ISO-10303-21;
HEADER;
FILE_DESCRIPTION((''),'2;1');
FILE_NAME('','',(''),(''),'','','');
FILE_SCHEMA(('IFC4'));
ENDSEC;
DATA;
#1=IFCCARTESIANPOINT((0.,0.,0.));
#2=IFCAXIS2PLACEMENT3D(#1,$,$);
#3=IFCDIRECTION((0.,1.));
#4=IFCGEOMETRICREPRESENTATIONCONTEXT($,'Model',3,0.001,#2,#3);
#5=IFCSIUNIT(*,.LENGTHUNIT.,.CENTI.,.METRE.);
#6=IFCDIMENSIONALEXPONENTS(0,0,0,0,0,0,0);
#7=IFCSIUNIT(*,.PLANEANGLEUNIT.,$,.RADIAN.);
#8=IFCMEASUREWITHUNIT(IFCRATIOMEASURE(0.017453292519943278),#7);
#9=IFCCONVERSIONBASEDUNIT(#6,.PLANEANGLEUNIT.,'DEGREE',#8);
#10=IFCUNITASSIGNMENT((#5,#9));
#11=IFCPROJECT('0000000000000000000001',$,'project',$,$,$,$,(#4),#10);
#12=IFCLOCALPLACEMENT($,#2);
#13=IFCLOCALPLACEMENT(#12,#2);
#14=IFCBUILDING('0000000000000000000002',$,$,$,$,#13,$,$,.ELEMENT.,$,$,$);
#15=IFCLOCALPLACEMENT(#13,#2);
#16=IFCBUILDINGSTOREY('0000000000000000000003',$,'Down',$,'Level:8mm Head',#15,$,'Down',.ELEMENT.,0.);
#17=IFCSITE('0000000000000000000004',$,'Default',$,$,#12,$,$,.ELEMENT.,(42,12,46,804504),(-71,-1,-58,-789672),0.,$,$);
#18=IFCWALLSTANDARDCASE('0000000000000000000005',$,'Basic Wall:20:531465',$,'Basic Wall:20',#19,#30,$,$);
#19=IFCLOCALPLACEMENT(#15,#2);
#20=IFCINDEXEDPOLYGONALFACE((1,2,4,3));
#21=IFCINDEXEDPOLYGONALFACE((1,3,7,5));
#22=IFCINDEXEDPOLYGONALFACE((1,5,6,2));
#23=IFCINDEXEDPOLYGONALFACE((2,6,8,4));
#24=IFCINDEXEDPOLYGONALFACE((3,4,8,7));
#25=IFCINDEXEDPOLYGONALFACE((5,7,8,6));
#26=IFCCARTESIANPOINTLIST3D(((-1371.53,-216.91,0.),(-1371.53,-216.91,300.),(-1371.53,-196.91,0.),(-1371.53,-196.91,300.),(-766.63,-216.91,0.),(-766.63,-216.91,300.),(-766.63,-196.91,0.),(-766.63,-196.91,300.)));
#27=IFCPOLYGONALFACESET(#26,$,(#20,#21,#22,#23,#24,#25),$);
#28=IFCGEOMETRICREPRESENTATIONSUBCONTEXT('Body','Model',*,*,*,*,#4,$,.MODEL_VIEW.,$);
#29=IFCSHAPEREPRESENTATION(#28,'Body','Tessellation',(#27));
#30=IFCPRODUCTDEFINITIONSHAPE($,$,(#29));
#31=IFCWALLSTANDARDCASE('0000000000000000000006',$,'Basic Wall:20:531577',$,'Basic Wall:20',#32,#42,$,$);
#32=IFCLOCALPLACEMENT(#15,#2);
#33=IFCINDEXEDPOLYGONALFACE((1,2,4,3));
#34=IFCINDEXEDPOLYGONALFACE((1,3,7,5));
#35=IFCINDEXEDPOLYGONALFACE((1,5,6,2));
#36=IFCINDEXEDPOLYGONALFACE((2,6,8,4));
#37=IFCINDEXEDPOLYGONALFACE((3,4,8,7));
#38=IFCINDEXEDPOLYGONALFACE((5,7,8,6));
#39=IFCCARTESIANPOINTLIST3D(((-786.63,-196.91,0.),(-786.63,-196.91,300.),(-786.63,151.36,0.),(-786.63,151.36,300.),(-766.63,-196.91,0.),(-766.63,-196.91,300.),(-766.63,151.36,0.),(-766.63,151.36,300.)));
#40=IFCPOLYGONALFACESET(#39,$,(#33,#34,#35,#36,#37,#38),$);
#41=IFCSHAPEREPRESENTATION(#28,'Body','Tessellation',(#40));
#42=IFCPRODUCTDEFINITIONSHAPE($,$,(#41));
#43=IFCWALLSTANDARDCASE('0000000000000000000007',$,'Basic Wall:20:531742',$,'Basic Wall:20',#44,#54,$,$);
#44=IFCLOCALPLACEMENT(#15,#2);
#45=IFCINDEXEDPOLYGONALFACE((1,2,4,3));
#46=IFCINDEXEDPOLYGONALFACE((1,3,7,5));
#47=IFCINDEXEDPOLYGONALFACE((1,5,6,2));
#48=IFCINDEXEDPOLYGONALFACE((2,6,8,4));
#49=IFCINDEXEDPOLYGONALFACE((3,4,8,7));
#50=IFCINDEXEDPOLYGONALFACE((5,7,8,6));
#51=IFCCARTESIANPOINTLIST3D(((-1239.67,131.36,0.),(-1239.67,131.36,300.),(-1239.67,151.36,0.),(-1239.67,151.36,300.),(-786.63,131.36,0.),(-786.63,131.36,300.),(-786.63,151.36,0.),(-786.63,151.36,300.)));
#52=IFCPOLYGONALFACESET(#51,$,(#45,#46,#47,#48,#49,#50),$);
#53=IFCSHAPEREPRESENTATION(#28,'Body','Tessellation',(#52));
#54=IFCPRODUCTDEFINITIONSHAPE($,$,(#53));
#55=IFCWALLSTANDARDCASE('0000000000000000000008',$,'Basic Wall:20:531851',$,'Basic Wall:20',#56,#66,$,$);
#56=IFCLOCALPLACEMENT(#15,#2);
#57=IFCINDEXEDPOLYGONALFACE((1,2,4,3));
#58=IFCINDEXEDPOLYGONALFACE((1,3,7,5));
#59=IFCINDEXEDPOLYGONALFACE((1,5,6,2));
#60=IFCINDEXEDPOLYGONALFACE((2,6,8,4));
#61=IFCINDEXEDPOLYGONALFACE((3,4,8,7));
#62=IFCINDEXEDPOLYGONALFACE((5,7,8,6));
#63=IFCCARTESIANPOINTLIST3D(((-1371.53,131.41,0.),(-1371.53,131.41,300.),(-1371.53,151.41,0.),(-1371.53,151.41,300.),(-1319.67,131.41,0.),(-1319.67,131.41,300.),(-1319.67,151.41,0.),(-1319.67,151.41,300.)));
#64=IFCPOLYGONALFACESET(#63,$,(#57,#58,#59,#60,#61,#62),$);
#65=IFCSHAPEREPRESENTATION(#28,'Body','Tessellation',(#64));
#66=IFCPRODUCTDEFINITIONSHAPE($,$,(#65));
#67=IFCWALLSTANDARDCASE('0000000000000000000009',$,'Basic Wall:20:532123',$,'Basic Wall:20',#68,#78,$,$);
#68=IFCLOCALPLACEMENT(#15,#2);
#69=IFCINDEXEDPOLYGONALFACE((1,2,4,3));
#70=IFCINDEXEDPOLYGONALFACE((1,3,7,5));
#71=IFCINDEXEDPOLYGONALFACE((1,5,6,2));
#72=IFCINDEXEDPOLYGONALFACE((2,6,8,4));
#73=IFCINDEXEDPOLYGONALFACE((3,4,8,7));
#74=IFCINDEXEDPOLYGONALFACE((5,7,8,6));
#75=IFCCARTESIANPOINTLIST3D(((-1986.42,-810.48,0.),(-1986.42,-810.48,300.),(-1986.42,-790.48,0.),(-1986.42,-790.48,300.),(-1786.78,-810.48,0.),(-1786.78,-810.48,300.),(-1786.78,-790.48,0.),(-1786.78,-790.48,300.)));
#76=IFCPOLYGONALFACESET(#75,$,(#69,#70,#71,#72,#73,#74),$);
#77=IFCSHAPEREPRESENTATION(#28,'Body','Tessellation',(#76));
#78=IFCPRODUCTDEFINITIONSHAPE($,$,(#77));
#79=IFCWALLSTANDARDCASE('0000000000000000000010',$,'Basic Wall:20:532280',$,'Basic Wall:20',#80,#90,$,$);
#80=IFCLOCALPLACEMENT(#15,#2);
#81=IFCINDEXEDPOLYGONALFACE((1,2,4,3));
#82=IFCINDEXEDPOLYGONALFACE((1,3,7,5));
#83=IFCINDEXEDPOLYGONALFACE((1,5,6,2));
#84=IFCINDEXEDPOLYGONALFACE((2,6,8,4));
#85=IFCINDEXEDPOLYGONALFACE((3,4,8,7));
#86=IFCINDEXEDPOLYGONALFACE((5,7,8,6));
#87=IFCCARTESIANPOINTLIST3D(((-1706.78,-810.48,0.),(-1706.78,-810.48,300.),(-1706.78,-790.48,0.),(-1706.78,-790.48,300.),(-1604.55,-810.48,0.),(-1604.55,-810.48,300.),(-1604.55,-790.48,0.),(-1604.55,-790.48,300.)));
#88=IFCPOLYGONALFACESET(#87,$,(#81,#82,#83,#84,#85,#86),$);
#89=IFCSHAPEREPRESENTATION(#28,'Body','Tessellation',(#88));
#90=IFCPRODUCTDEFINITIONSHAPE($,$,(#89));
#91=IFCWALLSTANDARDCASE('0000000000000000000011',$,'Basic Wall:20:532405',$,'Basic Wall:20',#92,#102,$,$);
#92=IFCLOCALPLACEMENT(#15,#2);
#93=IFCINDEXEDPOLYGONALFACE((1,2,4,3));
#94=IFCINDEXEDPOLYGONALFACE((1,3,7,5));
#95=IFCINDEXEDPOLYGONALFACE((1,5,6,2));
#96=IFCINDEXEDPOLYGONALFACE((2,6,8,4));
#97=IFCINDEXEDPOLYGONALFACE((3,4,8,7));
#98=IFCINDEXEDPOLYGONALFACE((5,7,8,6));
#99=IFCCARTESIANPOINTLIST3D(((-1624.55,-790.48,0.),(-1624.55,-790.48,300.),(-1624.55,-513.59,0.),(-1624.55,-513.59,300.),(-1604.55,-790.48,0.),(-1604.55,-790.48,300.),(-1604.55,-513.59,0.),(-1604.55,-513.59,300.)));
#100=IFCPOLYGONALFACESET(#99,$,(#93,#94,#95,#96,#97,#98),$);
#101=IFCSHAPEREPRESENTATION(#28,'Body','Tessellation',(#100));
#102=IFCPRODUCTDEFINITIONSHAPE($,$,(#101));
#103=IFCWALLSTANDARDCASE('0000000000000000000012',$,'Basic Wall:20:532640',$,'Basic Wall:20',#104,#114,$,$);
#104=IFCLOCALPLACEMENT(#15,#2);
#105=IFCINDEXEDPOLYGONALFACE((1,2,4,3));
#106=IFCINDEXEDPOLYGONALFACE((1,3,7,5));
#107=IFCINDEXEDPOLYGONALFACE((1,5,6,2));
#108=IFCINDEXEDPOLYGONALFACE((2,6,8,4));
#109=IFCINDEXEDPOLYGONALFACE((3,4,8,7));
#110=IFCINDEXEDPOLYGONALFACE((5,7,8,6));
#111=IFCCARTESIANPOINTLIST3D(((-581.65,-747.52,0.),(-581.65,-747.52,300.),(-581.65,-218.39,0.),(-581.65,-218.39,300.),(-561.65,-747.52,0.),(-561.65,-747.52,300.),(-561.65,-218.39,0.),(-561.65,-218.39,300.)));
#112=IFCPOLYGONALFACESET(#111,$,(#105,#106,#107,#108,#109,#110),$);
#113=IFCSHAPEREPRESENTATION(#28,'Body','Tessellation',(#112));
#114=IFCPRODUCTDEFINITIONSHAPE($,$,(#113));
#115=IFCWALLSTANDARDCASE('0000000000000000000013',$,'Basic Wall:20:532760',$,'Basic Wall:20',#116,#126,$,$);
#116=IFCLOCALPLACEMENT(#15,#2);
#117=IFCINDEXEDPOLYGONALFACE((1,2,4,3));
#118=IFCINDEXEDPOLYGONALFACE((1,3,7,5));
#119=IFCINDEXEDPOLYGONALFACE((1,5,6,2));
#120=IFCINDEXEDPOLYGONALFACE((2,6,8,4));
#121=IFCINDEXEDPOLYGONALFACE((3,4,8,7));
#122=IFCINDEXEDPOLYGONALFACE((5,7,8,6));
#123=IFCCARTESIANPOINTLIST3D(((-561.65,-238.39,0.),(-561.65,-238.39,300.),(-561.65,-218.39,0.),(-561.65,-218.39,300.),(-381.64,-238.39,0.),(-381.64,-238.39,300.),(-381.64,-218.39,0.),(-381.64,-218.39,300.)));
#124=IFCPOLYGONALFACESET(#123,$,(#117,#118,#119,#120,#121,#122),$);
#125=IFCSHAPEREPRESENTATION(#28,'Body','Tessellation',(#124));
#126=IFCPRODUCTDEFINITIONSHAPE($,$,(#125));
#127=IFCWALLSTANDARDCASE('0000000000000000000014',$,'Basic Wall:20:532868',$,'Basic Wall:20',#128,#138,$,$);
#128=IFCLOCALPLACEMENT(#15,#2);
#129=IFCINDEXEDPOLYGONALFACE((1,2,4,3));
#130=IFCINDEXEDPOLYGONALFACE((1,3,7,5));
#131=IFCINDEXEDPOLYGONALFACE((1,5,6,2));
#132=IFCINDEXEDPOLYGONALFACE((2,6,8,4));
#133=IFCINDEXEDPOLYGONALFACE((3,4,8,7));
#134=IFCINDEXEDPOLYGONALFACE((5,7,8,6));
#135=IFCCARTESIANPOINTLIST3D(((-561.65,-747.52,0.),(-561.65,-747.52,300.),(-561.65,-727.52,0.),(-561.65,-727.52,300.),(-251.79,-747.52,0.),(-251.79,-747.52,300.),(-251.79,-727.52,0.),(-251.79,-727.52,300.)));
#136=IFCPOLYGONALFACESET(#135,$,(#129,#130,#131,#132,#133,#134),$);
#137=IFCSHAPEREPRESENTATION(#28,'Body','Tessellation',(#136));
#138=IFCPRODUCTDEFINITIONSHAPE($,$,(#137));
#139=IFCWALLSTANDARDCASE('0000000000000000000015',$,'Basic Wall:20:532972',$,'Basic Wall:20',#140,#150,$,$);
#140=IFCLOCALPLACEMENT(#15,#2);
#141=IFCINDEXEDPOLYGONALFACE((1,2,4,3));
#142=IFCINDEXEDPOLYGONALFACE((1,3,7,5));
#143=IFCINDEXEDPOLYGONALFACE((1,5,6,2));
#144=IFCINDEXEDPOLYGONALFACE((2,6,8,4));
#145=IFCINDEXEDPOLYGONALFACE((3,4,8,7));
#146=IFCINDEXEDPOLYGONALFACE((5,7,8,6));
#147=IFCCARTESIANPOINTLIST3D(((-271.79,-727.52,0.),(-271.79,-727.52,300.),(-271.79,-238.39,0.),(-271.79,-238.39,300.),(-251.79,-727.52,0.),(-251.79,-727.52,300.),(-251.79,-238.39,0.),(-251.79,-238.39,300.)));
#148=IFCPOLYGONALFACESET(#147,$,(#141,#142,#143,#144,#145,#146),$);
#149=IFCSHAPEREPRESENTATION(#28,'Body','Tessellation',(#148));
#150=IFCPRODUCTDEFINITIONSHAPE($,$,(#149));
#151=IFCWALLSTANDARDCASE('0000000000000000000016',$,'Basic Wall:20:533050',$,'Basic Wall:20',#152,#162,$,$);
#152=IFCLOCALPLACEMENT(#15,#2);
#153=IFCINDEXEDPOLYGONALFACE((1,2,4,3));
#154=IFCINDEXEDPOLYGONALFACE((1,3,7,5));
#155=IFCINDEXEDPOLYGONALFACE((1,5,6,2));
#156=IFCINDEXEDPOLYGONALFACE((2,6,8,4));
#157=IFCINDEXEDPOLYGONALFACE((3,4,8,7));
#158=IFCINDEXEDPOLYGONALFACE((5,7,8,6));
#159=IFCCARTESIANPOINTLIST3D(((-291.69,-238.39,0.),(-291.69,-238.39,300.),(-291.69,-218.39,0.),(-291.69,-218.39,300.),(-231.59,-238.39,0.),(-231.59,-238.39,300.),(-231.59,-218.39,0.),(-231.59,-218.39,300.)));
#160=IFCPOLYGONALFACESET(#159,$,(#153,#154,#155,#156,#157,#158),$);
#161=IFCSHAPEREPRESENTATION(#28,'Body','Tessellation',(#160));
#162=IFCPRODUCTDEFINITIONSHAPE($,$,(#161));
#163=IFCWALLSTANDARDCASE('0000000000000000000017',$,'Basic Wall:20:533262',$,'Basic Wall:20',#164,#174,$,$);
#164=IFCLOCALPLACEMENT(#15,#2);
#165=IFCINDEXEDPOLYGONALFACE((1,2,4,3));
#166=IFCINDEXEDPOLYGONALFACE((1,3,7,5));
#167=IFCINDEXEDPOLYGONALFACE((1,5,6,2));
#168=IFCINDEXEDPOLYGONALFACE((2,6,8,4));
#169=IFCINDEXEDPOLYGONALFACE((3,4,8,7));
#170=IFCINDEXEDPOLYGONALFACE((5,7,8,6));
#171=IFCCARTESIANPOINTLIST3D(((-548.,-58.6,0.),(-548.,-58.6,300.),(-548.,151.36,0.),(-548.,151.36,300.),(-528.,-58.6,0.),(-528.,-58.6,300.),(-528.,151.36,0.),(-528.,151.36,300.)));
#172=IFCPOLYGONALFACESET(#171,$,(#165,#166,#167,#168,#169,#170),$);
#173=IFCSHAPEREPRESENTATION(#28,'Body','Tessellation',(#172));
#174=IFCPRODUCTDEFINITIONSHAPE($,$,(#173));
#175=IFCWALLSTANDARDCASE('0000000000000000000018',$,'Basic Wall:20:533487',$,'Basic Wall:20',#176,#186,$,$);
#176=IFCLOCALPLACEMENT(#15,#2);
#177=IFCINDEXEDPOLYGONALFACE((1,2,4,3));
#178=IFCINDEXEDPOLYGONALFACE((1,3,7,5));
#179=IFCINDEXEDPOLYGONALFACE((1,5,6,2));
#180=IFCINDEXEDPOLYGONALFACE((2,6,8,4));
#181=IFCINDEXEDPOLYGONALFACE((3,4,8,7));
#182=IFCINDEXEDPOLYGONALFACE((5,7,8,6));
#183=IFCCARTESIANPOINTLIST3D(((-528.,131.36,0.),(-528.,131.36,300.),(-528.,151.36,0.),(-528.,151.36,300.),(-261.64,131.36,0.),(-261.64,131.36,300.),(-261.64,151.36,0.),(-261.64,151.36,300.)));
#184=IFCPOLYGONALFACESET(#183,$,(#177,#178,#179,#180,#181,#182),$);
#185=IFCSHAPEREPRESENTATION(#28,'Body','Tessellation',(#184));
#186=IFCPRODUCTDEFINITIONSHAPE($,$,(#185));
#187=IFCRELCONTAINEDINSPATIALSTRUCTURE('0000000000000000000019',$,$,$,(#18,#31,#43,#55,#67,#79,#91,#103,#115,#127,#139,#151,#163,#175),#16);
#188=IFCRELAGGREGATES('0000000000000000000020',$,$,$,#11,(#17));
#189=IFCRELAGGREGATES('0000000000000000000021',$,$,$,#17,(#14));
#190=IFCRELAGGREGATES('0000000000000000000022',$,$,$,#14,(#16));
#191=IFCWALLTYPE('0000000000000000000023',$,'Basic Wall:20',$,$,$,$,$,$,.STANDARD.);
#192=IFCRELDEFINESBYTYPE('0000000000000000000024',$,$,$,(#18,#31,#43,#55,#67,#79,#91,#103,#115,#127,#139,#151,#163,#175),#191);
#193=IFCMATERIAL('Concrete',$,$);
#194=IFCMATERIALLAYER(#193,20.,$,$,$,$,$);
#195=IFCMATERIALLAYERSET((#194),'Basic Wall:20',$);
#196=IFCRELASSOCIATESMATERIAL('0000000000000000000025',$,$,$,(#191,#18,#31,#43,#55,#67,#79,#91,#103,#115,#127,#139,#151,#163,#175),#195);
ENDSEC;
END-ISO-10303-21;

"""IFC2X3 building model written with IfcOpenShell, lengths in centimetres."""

from ifc_helpers import new_model, entity, si_unit, converted_unit, direction, frame, frame_2d, origin, place, context, subcontext, project, spatial, rectangle, extrude, material, layer, layer_set, layer_usage, type_object, element, save


model = new_model("IFC2X3")

# Units and contexts
model_context = context("Model", 3, precision=0.001, world=origin(), true_north=direction((0.0, 1.0)))
body_context = subcontext(model_context, "Body", "Model", "MODEL_VIEW")
ifc_project = project(units=[si_unit("LENGTHUNIT", "METRE", prefix="CENTI"), converted_unit("PLANEANGLEUNIT", "DEGREE", entity("IfcRatioMeasure", 0.017453292519943278), si_unit("PLANEANGLEUNIT", "RADIAN"), dimensions=[0, 0, 0, 0, 0, 0, 0])], contexts=[model_context])

# Site, building, storey
site_placement = place(None, origin())
site = spatial("IfcSite", under=ifc_project, at=site_placement, Name="Default", CompositionType="ELEMENT", RefLatitude=(42, 12, 46, 804504), RefLongitude=(-71, -1, -58, -789672), RefElevation=0.0)
building_placement = place(site_placement, origin())
building = spatial("IfcBuilding", under=site, at=building_placement, CompositionType="ELEMENT")
storey_placement = place(building_placement, origin())
storey = spatial("IfcBuildingStorey", under=building, at=storey_placement, Name="Down", ObjectType="Level:8mm Head", LongName="Down", CompositionType="ELEMENT", Elevation=0.0)

# Shared definitions
ifc_material = material(Name="Concrete")

# Walls
ifc_layer_1 = layer(ifc_material, 20.0)
ifc_layer_set_1 = layer_set([ifc_layer_1], Name="Basic Wall:20")
ifc_layer_usage_1 = layer_usage(ifc_layer_set_1, "AXIS2", "POSITIVE", -10.0)
wall_type_1 = type_object("IfcWallType", Name="Basic Wall:20", PredefinedType="STANDARD", material=ifc_layer_set_1)
wall_1_placement = place(storey_placement, frame((-1371.53, -206.91, 0.0)))
element("IfcWallStandardCase", 1, at=wall_1_placement, inside=storey, type_object=wall_type_1, material=ifc_layer_usage_1, Name="Basic Wall:20:531465", ObjectType="Basic Wall:20", context=body_context, shape_type="SweptSolid", body=[
    extrude(rectangle(XDim=604.9, YDim=20.0, at=frame_2d((302.45, 0.0), x_axis=(-1.0, 0.0))), origin(), (0.0, 0.0, 1.0), 300.0),
])
ifc_layer_usage_2 = layer_usage(ifc_layer_set_1, "AXIS2", "POSITIVE", -10.0)
wall_2_placement = place(storey_placement, frame((-776.63, -196.91, 0.0), z_axis=(0.0, 0.0, 1.0), x_axis=(0.0, 1.0, 0.0)))
element("IfcWallStandardCase", 2, at=wall_2_placement, inside=storey, type_object=wall_type_1, material=ifc_layer_usage_2, Name="Basic Wall:20:531577", ObjectType="Basic Wall:20", context=body_context, shape_type="SweptSolid", body=[
    extrude(rectangle(XDim=348.27, YDim=20.0, at=frame_2d((174.14, 0.0), x_axis=(-1.0, 0.0))), origin(), (0.0, 0.0, 1.0), 300.0),
])
ifc_layer_usage_3 = layer_usage(ifc_layer_set_1, "AXIS2", "POSITIVE", -10.0)
wall_3_placement = place(storey_placement, frame((-786.63, 141.36, 0.0), z_axis=(0.0, 0.0, 1.0), x_axis=(-1.0, 0.0, 0.0)))
element("IfcWallStandardCase", 3, at=wall_3_placement, inside=storey, type_object=wall_type_1, material=ifc_layer_usage_3, Name="Basic Wall:20:531742", ObjectType="Basic Wall:20", context=body_context, shape_type="SweptSolid", body=[
    extrude(rectangle(XDim=453.04, YDim=20.0, at=frame_2d((226.52, 0.0), x_axis=(-1.0, 0.0))), origin(), (0.0, 0.0, 1.0), 300.0),
])
ifc_layer_usage_4 = layer_usage(ifc_layer_set_1, "AXIS2", "POSITIVE", -10.0)
wall_4_placement = place(storey_placement, frame((-1319.67, 141.41, 0.0), z_axis=(0.0, 0.0, 1.0), x_axis=(-1.0, 0.0, 0.0)))
element("IfcWallStandardCase", 4, at=wall_4_placement, inside=storey, type_object=wall_type_1, material=ifc_layer_usage_4, Name="Basic Wall:20:531851", ObjectType="Basic Wall:20", context=body_context, shape_type="SweptSolid", body=[
    extrude(rectangle(XDim=51.85, YDim=20.0, at=frame_2d((25.93, 0.0), x_axis=(-1.0, 0.0))), origin(), (0.0, 0.0, 1.0), 300.0),
])
ifc_layer_usage_5 = layer_usage(ifc_layer_set_1, "AXIS2", "NEGATIVE", 10.0)
wall_5_placement = place(storey_placement, frame((-1986.42, -800.48, 0.0)))
element("IfcWallStandardCase", 5, at=wall_5_placement, inside=storey, type_object=wall_type_1, material=ifc_layer_usage_5, Name="Basic Wall:20:532123", ObjectType="Basic Wall:20", context=body_context, shape_type="SweptSolid", body=[
    extrude(rectangle(XDim=199.64, YDim=20.0, at=frame_2d((99.82, 0.0), x_axis=(-1.0, 0.0))), origin(), (0.0, 0.0, 1.0), 300.0),
])
ifc_layer_usage_6 = layer_usage(ifc_layer_set_1, "AXIS2", "NEGATIVE", 10.0)
wall_6_placement = place(storey_placement, frame((-1706.78, -800.48, 0.0)))
element("IfcWallStandardCase", 6, at=wall_6_placement, inside=storey, type_object=wall_type_1, material=ifc_layer_usage_6, Name="Basic Wall:20:532280", ObjectType="Basic Wall:20", context=body_context, shape_type="SweptSolid", body=[
    extrude(rectangle(XDim=102.23, YDim=20.0, at=frame_2d((51.11, 0.0), x_axis=(-1.0, 0.0))), origin(), (0.0, 0.0, 1.0), 300.0),
])
ifc_layer_usage_7 = layer_usage(ifc_layer_set_1, "AXIS2", "POSITIVE", -10.0)
wall_7_placement = place(storey_placement, frame((-1614.55, -790.48, 0.0), z_axis=(0.0, 0.0, 1.0), x_axis=(0.0, 1.0, 0.0)))
element("IfcWallStandardCase", 7, at=wall_7_placement, inside=storey, type_object=wall_type_1, material=ifc_layer_usage_7, Name="Basic Wall:20:532405", ObjectType="Basic Wall:20", context=body_context, shape_type="SweptSolid", body=[
    extrude(rectangle(XDim=276.89, YDim=20.0, at=frame_2d((138.45, 0.0), x_axis=(-1.0, 0.0))), origin(), (0.0, 0.0, 1.0), 300.0),
])
ifc_layer_usage_8 = layer_usage(ifc_layer_set_1, "AXIS2", "POSITIVE", -10.0)
wall_8_placement = place(storey_placement, frame((-571.65, -218.39, 0.0), z_axis=(0.0, 0.0, 1.0), x_axis=(0.0, -1.0, 0.0)))
element("IfcWallStandardCase", 8, at=wall_8_placement, inside=storey, type_object=wall_type_1, material=ifc_layer_usage_8, Name="Basic Wall:20:532640", ObjectType="Basic Wall:20", context=body_context, shape_type="SweptSolid", body=[
    extrude(rectangle(XDim=529.12, YDim=20.0, at=frame_2d((264.56, 0.0), x_axis=(-1.0, 0.0))), origin(), (0.0, 0.0, 1.0), 300.0),
])
ifc_layer_usage_9 = layer_usage(ifc_layer_set_1, "AXIS2", "NEGATIVE", 10.0)
wall_9_placement = place(storey_placement, frame((-561.65, -228.39, 0.0)))
element("IfcWallStandardCase", 9, at=wall_9_placement, inside=storey, type_object=wall_type_1, material=ifc_layer_usage_9, Name="Basic Wall:20:532760", ObjectType="Basic Wall:20", context=body_context, shape_type="SweptSolid", body=[
    extrude(rectangle(XDim=180.01, YDim=20.0, at=frame_2d((90.0, 0.0), x_axis=(-1.0, 0.0))), origin(), (0.0, 0.0, 1.0), 300.0),
])
ifc_layer_usage_10 = layer_usage(ifc_layer_set_1, "AXIS2", "POSITIVE", -10.0)
wall_10_placement = place(storey_placement, frame((-561.65, -737.52, 0.0)))
element("IfcWallStandardCase", 10, at=wall_10_placement, inside=storey, type_object=wall_type_1, material=ifc_layer_usage_10, Name="Basic Wall:20:532868", ObjectType="Basic Wall:20", context=body_context, shape_type="SweptSolid", body=[
    extrude(rectangle(XDim=309.86, YDim=20.0, at=frame_2d((154.93, 0.0), x_axis=(-1.0, 0.0))), origin(), (0.0, 0.0, 1.0), 300.0),
])
ifc_layer_usage_11 = layer_usage(ifc_layer_set_1, "AXIS2", "POSITIVE", -10.0)
wall_11_placement = place(storey_placement, frame((-261.79, -238.39, 0.0), z_axis=(0.0, 0.0, 1.0), x_axis=(0.0, -1.0, 0.0)))
element("IfcWallStandardCase", 11, at=wall_11_placement, inside=storey, type_object=wall_type_1, material=ifc_layer_usage_11, Name="Basic Wall:20:532972", ObjectType="Basic Wall:20", context=body_context, shape_type="SweptSolid", body=[
    extrude(rectangle(XDim=489.12, YDim=20.0, at=frame_2d((244.56, 0.0), x_axis=(-1.0, 0.0))), origin(), (0.0, 0.0, 1.0), 300.0),
])
ifc_layer_usage_12 = layer_usage(ifc_layer_set_1, "AXIS2", "NEGATIVE", 10.0)
wall_12_placement = place(storey_placement, frame((-291.69, -228.39, 0.0)))
element("IfcWallStandardCase", 12, at=wall_12_placement, inside=storey, type_object=wall_type_1, material=ifc_layer_usage_12, Name="Basic Wall:20:533050", ObjectType="Basic Wall:20", context=body_context, shape_type="SweptSolid", body=[
    extrude(rectangle(XDim=60.1, YDim=20.0, at=frame_2d((30.05, 0.0), x_axis=(-1.0, 0.0))), origin(), (0.0, 0.0, 1.0), 300.0),
])
ifc_layer_usage_13 = layer_usage(ifc_layer_set_1, "AXIS2", "NEGATIVE", 10.0)
wall_13_placement = place(storey_placement, frame((-538.0, -58.6, 0.0), z_axis=(0.0, 0.0, 1.0), x_axis=(0.0, 1.0, 0.0)))
element("IfcWallStandardCase", 13, at=wall_13_placement, inside=storey, type_object=wall_type_1, material=ifc_layer_usage_13, Name="Basic Wall:20:533262", ObjectType="Basic Wall:20", context=body_context, shape_type="SweptSolid", body=[
    extrude(rectangle(XDim=209.96, YDim=20.0, at=frame_2d((104.98, 0.0), x_axis=(-1.0, 0.0))), origin(), (0.0, 0.0, 1.0), 300.0),
])
ifc_layer_usage_14 = layer_usage(ifc_layer_set_1, "AXIS2", "NEGATIVE", 10.0)
wall_14_placement = place(storey_placement, frame((-528.0, 141.36, 0.0)))
element("IfcWallStandardCase", 14, at=wall_14_placement, inside=storey, type_object=wall_type_1, material=ifc_layer_usage_14, Name="Basic Wall:20:533487", ObjectType="Basic Wall:20", context=body_context, shape_type="SweptSolid", body=[
    extrude(rectangle(XDim=266.36, YDim=20.0, at=frame_2d((133.18, 0.0), x_axis=(-1.0, 0.0))), origin(), (0.0, 0.0, 1.0), 300.0),
])

save(model, "model.ifc")
